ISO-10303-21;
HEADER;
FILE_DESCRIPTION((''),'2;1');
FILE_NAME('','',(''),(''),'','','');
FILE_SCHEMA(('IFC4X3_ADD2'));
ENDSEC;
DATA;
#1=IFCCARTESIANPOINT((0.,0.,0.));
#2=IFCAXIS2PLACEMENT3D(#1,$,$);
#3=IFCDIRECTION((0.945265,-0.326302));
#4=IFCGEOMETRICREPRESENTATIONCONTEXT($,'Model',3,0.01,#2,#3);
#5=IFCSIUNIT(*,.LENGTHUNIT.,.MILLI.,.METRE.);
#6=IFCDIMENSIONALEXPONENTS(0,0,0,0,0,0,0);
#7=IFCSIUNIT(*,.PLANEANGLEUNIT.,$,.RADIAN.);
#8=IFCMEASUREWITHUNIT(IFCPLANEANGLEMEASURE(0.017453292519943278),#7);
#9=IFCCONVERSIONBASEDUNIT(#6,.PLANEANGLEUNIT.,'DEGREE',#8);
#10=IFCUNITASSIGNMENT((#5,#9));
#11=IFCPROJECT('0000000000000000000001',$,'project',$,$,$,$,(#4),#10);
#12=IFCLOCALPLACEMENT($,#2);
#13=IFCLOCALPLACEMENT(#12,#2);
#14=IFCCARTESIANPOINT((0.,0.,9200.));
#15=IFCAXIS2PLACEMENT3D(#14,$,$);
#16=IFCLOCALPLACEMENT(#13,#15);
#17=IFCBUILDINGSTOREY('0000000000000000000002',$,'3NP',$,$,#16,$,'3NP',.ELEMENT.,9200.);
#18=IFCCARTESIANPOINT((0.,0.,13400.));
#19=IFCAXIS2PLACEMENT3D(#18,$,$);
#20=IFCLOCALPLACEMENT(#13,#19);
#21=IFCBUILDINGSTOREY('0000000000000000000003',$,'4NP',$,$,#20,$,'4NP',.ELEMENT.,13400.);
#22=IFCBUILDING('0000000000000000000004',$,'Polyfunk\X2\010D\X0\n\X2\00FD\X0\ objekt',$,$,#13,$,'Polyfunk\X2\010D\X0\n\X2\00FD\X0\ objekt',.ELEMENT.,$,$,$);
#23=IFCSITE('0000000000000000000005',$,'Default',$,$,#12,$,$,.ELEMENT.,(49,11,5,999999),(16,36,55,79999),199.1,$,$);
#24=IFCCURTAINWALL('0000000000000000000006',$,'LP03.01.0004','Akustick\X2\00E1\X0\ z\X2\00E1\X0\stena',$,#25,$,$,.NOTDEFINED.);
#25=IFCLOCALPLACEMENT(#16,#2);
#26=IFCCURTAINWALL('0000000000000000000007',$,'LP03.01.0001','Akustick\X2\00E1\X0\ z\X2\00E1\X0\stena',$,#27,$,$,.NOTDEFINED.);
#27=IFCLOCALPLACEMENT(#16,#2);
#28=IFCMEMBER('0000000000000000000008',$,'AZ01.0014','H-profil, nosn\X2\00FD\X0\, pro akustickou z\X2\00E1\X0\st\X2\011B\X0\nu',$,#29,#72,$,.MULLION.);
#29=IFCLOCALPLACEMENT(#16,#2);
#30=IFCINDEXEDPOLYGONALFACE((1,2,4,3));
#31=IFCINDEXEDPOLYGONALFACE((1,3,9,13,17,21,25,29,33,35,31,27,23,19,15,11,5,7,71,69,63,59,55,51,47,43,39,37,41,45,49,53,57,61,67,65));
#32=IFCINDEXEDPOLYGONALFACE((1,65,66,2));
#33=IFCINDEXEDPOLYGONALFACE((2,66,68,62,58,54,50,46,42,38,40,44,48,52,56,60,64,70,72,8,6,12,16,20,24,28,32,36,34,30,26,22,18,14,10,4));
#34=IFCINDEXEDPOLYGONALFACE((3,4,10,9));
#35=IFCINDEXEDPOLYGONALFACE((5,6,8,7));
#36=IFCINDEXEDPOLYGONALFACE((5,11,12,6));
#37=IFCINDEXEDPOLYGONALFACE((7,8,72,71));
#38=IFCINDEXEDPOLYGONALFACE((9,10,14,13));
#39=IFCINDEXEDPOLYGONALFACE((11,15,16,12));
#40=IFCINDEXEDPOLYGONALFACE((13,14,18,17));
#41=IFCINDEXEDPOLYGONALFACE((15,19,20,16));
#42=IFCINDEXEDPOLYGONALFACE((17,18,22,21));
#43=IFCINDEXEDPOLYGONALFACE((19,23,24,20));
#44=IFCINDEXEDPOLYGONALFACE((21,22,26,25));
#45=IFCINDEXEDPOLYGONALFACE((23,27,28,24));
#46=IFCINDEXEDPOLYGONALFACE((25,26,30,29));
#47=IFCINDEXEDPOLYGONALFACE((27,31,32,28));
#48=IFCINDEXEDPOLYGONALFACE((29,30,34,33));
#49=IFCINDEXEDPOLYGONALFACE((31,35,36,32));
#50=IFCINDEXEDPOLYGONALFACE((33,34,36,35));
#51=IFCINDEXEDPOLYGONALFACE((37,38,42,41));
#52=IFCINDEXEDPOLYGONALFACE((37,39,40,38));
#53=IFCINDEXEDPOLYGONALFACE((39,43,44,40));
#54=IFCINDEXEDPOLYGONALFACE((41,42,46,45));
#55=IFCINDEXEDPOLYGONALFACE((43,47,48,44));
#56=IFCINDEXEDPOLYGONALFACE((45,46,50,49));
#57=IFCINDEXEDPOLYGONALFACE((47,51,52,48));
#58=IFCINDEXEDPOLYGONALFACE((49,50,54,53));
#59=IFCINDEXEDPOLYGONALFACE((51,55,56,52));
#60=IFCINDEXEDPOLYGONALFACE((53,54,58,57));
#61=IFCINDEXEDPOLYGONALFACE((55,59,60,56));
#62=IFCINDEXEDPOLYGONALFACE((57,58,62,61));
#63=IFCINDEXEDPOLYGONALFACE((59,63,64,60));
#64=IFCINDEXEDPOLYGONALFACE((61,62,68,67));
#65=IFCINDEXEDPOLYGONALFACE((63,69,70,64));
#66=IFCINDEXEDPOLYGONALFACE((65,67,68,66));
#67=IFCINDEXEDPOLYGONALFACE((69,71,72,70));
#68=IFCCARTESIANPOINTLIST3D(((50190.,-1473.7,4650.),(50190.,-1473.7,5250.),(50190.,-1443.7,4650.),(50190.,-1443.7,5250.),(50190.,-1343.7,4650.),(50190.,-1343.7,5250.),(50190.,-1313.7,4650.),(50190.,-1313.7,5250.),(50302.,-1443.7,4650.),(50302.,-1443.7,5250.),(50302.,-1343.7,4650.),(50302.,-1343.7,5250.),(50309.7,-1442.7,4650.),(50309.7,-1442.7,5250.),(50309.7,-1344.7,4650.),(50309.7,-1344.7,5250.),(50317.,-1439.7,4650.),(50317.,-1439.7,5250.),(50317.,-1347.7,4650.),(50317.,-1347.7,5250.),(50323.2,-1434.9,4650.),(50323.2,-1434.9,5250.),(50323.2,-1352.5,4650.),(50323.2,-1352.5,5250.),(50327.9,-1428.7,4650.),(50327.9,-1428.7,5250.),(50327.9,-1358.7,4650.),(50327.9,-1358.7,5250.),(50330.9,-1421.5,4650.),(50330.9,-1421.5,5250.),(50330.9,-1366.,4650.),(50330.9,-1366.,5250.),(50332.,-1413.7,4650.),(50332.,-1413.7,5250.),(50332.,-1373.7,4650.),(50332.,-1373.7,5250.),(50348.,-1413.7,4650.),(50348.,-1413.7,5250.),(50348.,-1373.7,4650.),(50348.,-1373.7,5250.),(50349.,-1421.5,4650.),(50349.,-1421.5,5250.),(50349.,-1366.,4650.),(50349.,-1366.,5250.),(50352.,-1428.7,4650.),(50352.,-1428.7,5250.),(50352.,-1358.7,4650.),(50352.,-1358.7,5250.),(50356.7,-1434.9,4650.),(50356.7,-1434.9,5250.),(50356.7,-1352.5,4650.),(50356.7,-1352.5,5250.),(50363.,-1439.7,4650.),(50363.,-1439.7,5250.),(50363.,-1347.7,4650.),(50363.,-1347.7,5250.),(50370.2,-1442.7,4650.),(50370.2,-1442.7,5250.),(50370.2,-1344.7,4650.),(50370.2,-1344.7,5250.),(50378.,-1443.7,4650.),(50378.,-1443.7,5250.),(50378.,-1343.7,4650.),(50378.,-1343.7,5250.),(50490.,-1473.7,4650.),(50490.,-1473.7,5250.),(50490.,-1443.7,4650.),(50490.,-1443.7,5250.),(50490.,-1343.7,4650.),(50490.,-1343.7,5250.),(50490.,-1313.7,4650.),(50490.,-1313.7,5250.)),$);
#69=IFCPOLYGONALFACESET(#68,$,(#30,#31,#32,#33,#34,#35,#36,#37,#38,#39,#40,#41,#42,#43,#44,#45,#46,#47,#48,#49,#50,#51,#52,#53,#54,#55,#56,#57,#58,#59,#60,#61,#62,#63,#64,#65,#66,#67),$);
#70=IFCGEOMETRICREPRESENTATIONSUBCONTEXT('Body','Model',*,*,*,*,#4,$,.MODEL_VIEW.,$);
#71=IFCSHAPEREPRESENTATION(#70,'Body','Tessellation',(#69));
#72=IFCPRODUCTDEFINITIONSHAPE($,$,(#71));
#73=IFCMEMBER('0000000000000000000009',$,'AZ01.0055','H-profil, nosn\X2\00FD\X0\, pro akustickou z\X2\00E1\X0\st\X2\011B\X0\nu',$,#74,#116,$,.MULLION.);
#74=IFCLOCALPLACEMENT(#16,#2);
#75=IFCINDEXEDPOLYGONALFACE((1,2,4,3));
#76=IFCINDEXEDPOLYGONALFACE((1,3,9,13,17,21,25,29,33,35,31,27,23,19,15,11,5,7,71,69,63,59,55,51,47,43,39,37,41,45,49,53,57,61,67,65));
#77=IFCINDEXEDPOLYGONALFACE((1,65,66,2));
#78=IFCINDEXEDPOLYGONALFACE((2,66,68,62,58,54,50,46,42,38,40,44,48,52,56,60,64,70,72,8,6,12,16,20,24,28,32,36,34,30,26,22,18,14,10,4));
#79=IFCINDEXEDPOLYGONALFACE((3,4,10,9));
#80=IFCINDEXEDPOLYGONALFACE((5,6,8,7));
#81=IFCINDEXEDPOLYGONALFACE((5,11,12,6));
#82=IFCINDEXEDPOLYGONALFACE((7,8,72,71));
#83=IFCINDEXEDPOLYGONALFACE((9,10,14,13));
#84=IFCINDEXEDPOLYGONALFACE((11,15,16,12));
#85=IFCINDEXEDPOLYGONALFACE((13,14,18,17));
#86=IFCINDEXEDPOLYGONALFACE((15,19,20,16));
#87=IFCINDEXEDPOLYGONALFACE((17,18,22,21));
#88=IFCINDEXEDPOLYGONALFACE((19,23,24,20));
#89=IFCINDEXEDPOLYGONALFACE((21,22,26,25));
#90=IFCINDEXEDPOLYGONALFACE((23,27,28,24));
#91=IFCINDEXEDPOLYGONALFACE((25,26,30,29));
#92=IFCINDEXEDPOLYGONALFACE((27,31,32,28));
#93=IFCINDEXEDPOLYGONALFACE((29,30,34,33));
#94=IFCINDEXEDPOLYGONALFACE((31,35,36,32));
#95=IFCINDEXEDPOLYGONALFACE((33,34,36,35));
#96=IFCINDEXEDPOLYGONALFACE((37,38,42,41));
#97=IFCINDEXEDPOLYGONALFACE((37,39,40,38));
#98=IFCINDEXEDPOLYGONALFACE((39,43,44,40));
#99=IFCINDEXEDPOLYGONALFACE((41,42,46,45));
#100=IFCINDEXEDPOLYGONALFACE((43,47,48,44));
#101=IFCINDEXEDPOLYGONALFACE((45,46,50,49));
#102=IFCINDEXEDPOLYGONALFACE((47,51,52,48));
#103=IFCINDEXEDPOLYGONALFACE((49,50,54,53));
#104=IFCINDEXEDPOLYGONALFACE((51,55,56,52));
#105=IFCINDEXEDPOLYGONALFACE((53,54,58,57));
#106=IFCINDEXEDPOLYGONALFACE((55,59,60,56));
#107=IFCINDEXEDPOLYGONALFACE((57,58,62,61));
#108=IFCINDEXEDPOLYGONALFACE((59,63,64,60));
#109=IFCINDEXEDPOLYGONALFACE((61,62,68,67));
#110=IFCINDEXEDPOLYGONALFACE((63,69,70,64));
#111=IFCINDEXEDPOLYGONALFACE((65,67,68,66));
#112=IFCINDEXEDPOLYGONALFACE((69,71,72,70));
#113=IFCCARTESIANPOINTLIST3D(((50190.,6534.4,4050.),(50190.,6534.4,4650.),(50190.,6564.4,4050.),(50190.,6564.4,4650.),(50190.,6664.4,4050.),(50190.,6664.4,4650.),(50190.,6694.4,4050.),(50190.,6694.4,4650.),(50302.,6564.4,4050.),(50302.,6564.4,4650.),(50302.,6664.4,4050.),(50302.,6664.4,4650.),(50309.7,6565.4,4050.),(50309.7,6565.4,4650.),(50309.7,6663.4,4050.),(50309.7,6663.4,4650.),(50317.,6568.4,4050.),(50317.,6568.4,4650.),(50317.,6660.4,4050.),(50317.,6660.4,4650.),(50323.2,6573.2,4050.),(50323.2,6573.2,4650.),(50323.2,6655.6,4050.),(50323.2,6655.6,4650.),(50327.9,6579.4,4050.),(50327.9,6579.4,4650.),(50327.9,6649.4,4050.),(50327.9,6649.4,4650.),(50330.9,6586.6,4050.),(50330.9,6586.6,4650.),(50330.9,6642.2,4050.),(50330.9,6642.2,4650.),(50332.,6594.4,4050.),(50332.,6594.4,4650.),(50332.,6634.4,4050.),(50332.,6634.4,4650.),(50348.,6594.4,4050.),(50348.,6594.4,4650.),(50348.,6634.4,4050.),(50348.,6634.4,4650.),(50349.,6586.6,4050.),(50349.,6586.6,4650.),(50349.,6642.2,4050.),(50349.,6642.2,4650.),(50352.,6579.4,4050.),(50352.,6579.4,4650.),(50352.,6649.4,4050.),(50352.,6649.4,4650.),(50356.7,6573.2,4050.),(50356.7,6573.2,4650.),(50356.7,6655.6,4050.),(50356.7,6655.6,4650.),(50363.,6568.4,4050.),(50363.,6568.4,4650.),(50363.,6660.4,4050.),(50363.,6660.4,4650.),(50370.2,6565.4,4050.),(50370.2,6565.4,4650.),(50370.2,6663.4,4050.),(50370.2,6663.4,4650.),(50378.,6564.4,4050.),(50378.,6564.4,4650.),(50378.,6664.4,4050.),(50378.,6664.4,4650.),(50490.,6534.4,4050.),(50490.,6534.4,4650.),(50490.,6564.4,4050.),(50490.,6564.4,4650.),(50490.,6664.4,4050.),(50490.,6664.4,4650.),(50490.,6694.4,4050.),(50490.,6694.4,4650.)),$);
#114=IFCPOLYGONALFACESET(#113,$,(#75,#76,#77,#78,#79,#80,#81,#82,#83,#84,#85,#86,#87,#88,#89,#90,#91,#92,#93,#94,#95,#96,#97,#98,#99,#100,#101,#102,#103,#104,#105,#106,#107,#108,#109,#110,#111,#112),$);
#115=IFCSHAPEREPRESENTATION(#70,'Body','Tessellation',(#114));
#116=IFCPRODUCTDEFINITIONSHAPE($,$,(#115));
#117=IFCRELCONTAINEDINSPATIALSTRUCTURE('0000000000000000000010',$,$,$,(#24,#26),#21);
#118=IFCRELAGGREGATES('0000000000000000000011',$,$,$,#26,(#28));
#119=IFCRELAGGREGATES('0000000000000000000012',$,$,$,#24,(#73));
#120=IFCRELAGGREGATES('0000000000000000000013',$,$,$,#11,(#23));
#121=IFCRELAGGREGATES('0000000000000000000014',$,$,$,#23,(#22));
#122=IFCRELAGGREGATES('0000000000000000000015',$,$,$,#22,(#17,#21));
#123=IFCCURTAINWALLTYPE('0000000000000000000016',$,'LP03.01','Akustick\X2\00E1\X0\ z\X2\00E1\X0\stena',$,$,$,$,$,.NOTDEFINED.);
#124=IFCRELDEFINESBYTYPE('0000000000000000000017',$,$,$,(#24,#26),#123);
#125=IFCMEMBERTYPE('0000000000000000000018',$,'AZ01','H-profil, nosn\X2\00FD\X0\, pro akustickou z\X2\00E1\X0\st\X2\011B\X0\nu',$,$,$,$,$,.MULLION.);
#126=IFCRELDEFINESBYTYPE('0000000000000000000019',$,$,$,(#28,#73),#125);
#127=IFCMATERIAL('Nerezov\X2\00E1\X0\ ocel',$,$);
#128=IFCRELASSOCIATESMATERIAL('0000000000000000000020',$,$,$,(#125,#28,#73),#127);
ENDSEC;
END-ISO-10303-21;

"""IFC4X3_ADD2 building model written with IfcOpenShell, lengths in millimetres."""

from ifc_helpers import new_model, entity, si_unit, converted_unit, direction, frame, frame_2d, origin, place, context, subcontext, project, spatial, polyline, circle_curve, parameter, trimmed, segment, composite_curve, outline, extrude, source, transform, mapped, material, material_profile, profile_set, profile_usage, type_object, type_shapes, element, aggregate, save


model = new_model("IFC4X3_ADD2")

# Units and contexts
model_context = context("Model", 3, precision=0.01, world=origin(), true_north=direction((0.945265, -0.326302)))
body_context = subcontext(model_context, "Body", "Model", "MODEL_VIEW")
ifc_project = project(units=[si_unit("LENGTHUNIT", "METRE", prefix="MILLI"), converted_unit("PLANEANGLEUNIT", "DEGREE", entity("IfcPlaneAngleMeasure", 0.017453292519943278), si_unit("PLANEANGLEUNIT", "RADIAN"), dimensions=[0, 0, 0, 0, 0, 0, 0])], contexts=[model_context])

# Site, building, storey
site_placement = place(None, origin())
site = spatial("IfcSite", under=ifc_project, at=site_placement, Name="Default", CompositionType="ELEMENT", RefLatitude=(49, 11, 5, 999999), RefLongitude=(16, 36, 55, 79999), RefElevation=199.1)
building_placement = place(site_placement, origin())
building = spatial("IfcBuilding", under=site, at=building_placement, Name="Polyfunkčný objekt", LongName="Polyfunkčný objekt", CompositionType="ELEMENT")
storey_1_placement = place(building_placement, frame((0.0, 0.0, 9200.0)))
storey_1 = spatial("IfcBuildingStorey", under=building, at=storey_1_placement, Name="3NP", LongName="3NP", CompositionType="ELEMENT", Elevation=9200.0)

# Shared definitions
storey_2_placement = place(building_placement, frame((0.0, 0.0, 13400.0)))
storey_2 = spatial("IfcBuildingStorey", under=building, at=storey_2_placement, Name="4NP", LongName="4NP", CompositionType="ELEMENT", Elevation=13400.0)

# Curtain walls, member
curtain_wall_type_1 = type_object("IfcCurtainWallType", Name="LP03.01", Description="Akustická zástena", PredefinedType="NOTDEFINED")
curtain_wall_1_placement = place(storey_2_placement, frame((0.0, 0.0, -13400.0)))
curtain_wall_1 = element("IfcCurtainWall", 1, at=curtain_wall_1_placement, inside=storey_2, type_object=curtain_wall_type_1, Name="LP03.01.0004", Description="Akustická zástena", PredefinedType="NOTDEFINED")
ifc_material_1 = material(Name="Nerezová ocel")
ifc_material_profile_1 = material_profile(ifc_material_1, outline(composite_curve([segment(polyline([(50.0, -150.0), (80.0, -150.0)]), True, "CONTINUOUS"), segment(polyline([(80.0, -150.0), (80.0, 150.0)]), True, "CONTINUOUS"), segment(polyline([(80.0, 150.0), (50.0, 150.0)]), True, "CONTINUOUS"), segment(polyline([(50.0, 150.0), (50.0, 38.0)]), True, "CONTINUOUS"), segment(trimmed(circle_curve(frame_2d((20.0, 38.0), x_axis=(0.0, 1.0)), 30.0), [parameter(180.0)], [parameter(270.0)], True, "PARAMETER"), False, "CONTINUOUS"), segment(polyline([(20.0, 8.0), (-20.0, 8.0)]), True, "CONTINUOUS"), segment(trimmed(circle_curve(frame_2d((-20.0, 38.0), x_axis=(0.0, 1.0)), 30.0), [parameter(90.0)], [parameter(180.0)], True, "PARAMETER"), False, "CONTINUOUS"), segment(polyline([(-50.0, 38.0), (-50.0, 150.0)]), True, "CONTINUOUS"), segment(polyline([(-50.0, 150.0), (-80.0, 150.0)]), True, "CONTINUOUS"), segment(polyline([(-80.0, 150.0), (-80.0, -150.0)]), True, "CONTINUOUS"), segment(polyline([(-80.0, -150.0), (-50.0, -150.0)]), True, "CONTINUOUS"), segment(polyline([(-50.0, -150.0), (-50.0, -38.0)]), True, "CONTINUOUS"), segment(trimmed(circle_curve(frame_2d((-20.0, -38.0), x_axis=(0.0, 1.0)), 30.0), [parameter(0.0)], [parameter(90.0)], True, "PARAMETER"), False, "CONTINUOUS"), segment(polyline([(-20.0, -8.0), (20.0, -8.0)]), True, "CONTINUOUS"), segment(trimmed(circle_curve(frame_2d((20.0, -38.0), x_axis=(0.0, 1.0)), 30.0), [parameter(270.0)], [parameter(0.0)], True, "PARAMETER"), False, "CONTINUOUS"), segment(polyline([(50.0, -38.0), (50.0, -150.0)]), True, "CONTINUOUS")], self_intersect=False)), Name="Profil zástena")
ifc_profile_set_1 = profile_set([ifc_material_profile_1], Name="Profil zástena")
ifc_profile_usage_1 = profile_usage(ifc_profile_set_1)
member_type_1 = type_object("IfcMemberType", Name="AZ01", Description="H-profil, nosný, pro akustickou zástěnu", PredefinedType="MULLION", material=ifc_profile_set_1)
shared_shape_1 = source(origin(), body_context, "Body", "SweptSolid", [
    extrude(outline(composite_curve([segment(polyline([(-150.0, -50.0), (-150.0, -80.0)]), True, "CONTINUOUS"), segment(polyline([(-150.0, -80.0), (150.0, -80.0)]), True, "CONTINUOUS"), segment(polyline([(150.0, -80.0), (150.0, -50.0)]), True, "CONTINUOUS"), segment(polyline([(150.0, -50.0), (38.0, -50.0)]), True, "CONTINUOUS"), segment(trimmed(circle_curve(frame_2d((38.0, -20.0), x_axis=(1.0, 0.0)), 30.0), [parameter(180.0)], [parameter(270.0)], True, "PARAMETER"), False, "CONTINUOUS"), segment(polyline([(8.0, -20.0), (8.0, 20.0)]), True, "CONTINUOUS"), segment(trimmed(circle_curve(frame_2d((38.0, 20.0), x_axis=(1.0, 0.0)), 30.0), [parameter(90.0)], [parameter(180.0)], True, "PARAMETER"), False, "CONTINUOUS"), segment(polyline([(38.0, 50.0), (150.0, 50.0)]), True, "CONTINUOUS"), segment(polyline([(150.0, 50.0), (150.0, 80.0)]), True, "CONTINUOUS"), segment(polyline([(150.0, 80.0), (-150.0, 80.0)]), True, "CONTINUOUS"), segment(polyline([(-150.0, 80.0), (-150.0, 50.0)]), True, "CONTINUOUS"), segment(polyline([(-150.0, 50.0), (-38.0, 50.0)]), True, "CONTINUOUS"), segment(trimmed(circle_curve(frame_2d((-38.0, 20.0), x_axis=(1.0, 0.0)), 30.0), [parameter(0.0)], [parameter(90.0)], True, "PARAMETER"), False, "CONTINUOUS"), segment(polyline([(-8.0, 20.0), (-8.0, -20.0)]), True, "CONTINUOUS"), segment(trimmed(circle_curve(frame_2d((-38.0, -20.0), x_axis=(1.0, 0.0)), 30.0), [parameter(270.0)], [parameter(0.0)], True, "PARAMETER"), False, "CONTINUOUS"), segment(polyline([(-38.0, -50.0), (-150.0, -50.0)]), True, "CONTINUOUS")], self_intersect=False)), frame((-150.0, 0.0, -600.0), z_axis=(0.0, 0.0, -1.0), x_axis=(-1.0, 0.0, 0.0)), (0.0, 0.0, -1.0), 600.0),
])
curtain_wall_2_placement = place(storey_2_placement, frame((0.0, 0.0, -13400.0)))
curtain_wall_2 = element("IfcCurtainWall", 2, at=curtain_wall_2_placement, inside=storey_2, type_object=curtain_wall_type_1, Name="LP03.01.0001", Description="Akustická zástena", PredefinedType="NOTDEFINED")
member_1_placement = place(curtain_wall_2_placement, frame((50190.0, -1393.7, 14450.0), z_axis=(0.0, 0.0, 1.0), x_axis=(-1.0, 0.0, 0.0)))
member_1 = element("IfcMember", 3, at=member_1_placement, type_object=member_type_1, material=ifc_profile_usage_1, Name="AZ01.0014", Description="H-profil, nosný, pro akustickou zástěnu", PredefinedType="MULLION", context=body_context, shape_type="MappedRepresentation", body=[
    mapped(shared_shape_1, transform((0.0, 0.0, 0.0), scale=1.0)),
])

# Member
shared_shape_2 = source(origin(), body_context, "Body", "SweptSolid", [
    extrude(outline(composite_curve([segment(polyline([(-150.0, -50.0), (-150.0, -80.0)]), True, "CONTINUOUS"), segment(polyline([(-150.0, -80.0), (150.0, -80.0)]), True, "CONTINUOUS"), segment(polyline([(150.0, -80.0), (150.0, -50.0)]), True, "CONTINUOUS"), segment(polyline([(150.0, -50.0), (38.0, -50.0)]), True, "CONTINUOUS"), segment(trimmed(circle_curve(frame_2d((38.0, -20.0), x_axis=(1.0, 0.0)), 30.0), [parameter(180.0)], [parameter(270.0)], True, "PARAMETER"), False, "CONTINUOUS"), segment(polyline([(8.0, -20.0), (8.0, 20.0)]), True, "CONTINUOUS"), segment(trimmed(circle_curve(frame_2d((38.0, 20.0), x_axis=(1.0, 0.0)), 30.0), [parameter(90.0)], [parameter(180.0)], True, "PARAMETER"), False, "CONTINUOUS"), segment(polyline([(38.0, 50.0), (150.0, 50.0)]), True, "CONTINUOUS"), segment(polyline([(150.0, 50.0), (150.0, 80.0)]), True, "CONTINUOUS"), segment(polyline([(150.0, 80.0), (-150.0, 80.0)]), True, "CONTINUOUS"), segment(polyline([(-150.0, 80.0), (-150.0, 50.0)]), True, "CONTINUOUS"), segment(polyline([(-150.0, 50.0), (-38.0, 50.0)]), True, "CONTINUOUS"), segment(trimmed(circle_curve(frame_2d((-38.0, 20.0), x_axis=(1.0, 0.0)), 30.0), [parameter(0.0)], [parameter(90.0)], True, "PARAMETER"), False, "CONTINUOUS"), segment(polyline([(-8.0, 20.0), (-8.0, -20.0)]), True, "CONTINUOUS"), segment(trimmed(circle_curve(frame_2d((-38.0, -20.0), x_axis=(1.0, 0.0)), 30.0), [parameter(270.0)], [parameter(0.0)], True, "PARAMETER"), False, "CONTINUOUS"), segment(polyline([(-38.0, -50.0), (-150.0, -50.0)]), True, "CONTINUOUS")], self_intersect=False)), frame((-150.0, 0.0, -600.0), z_axis=(0.0, 0.0, -1.0), x_axis=(-1.0, 0.0, 0.0)), (0.0, 0.0, -1.0), 600.0),
])
type_shapes(member_type_1, [shared_shape_1, shared_shape_2])
member_2_placement = place(curtain_wall_1_placement, frame((50190.0, 6614.4, 13850.0), z_axis=(0.0, 0.0, 1.0), x_axis=(-1.0, 0.0, 0.0)))
member_2 = element("IfcMember", 4, at=member_2_placement, type_object=member_type_1, material=ifc_profile_usage_1, Name="AZ01.0055", Description="H-profil, nosný, pro akustickou zástěnu", PredefinedType="MULLION", context=body_context, shape_type="MappedRepresentation", body=[
    mapped(shared_shape_2, transform((0.0, 0.0, 0.0), scale=1.0)),
])
aggregate(curtain_wall_2, [member_1])

aggregate(curtain_wall_1, [member_2])

save(model, "model.ifc")
